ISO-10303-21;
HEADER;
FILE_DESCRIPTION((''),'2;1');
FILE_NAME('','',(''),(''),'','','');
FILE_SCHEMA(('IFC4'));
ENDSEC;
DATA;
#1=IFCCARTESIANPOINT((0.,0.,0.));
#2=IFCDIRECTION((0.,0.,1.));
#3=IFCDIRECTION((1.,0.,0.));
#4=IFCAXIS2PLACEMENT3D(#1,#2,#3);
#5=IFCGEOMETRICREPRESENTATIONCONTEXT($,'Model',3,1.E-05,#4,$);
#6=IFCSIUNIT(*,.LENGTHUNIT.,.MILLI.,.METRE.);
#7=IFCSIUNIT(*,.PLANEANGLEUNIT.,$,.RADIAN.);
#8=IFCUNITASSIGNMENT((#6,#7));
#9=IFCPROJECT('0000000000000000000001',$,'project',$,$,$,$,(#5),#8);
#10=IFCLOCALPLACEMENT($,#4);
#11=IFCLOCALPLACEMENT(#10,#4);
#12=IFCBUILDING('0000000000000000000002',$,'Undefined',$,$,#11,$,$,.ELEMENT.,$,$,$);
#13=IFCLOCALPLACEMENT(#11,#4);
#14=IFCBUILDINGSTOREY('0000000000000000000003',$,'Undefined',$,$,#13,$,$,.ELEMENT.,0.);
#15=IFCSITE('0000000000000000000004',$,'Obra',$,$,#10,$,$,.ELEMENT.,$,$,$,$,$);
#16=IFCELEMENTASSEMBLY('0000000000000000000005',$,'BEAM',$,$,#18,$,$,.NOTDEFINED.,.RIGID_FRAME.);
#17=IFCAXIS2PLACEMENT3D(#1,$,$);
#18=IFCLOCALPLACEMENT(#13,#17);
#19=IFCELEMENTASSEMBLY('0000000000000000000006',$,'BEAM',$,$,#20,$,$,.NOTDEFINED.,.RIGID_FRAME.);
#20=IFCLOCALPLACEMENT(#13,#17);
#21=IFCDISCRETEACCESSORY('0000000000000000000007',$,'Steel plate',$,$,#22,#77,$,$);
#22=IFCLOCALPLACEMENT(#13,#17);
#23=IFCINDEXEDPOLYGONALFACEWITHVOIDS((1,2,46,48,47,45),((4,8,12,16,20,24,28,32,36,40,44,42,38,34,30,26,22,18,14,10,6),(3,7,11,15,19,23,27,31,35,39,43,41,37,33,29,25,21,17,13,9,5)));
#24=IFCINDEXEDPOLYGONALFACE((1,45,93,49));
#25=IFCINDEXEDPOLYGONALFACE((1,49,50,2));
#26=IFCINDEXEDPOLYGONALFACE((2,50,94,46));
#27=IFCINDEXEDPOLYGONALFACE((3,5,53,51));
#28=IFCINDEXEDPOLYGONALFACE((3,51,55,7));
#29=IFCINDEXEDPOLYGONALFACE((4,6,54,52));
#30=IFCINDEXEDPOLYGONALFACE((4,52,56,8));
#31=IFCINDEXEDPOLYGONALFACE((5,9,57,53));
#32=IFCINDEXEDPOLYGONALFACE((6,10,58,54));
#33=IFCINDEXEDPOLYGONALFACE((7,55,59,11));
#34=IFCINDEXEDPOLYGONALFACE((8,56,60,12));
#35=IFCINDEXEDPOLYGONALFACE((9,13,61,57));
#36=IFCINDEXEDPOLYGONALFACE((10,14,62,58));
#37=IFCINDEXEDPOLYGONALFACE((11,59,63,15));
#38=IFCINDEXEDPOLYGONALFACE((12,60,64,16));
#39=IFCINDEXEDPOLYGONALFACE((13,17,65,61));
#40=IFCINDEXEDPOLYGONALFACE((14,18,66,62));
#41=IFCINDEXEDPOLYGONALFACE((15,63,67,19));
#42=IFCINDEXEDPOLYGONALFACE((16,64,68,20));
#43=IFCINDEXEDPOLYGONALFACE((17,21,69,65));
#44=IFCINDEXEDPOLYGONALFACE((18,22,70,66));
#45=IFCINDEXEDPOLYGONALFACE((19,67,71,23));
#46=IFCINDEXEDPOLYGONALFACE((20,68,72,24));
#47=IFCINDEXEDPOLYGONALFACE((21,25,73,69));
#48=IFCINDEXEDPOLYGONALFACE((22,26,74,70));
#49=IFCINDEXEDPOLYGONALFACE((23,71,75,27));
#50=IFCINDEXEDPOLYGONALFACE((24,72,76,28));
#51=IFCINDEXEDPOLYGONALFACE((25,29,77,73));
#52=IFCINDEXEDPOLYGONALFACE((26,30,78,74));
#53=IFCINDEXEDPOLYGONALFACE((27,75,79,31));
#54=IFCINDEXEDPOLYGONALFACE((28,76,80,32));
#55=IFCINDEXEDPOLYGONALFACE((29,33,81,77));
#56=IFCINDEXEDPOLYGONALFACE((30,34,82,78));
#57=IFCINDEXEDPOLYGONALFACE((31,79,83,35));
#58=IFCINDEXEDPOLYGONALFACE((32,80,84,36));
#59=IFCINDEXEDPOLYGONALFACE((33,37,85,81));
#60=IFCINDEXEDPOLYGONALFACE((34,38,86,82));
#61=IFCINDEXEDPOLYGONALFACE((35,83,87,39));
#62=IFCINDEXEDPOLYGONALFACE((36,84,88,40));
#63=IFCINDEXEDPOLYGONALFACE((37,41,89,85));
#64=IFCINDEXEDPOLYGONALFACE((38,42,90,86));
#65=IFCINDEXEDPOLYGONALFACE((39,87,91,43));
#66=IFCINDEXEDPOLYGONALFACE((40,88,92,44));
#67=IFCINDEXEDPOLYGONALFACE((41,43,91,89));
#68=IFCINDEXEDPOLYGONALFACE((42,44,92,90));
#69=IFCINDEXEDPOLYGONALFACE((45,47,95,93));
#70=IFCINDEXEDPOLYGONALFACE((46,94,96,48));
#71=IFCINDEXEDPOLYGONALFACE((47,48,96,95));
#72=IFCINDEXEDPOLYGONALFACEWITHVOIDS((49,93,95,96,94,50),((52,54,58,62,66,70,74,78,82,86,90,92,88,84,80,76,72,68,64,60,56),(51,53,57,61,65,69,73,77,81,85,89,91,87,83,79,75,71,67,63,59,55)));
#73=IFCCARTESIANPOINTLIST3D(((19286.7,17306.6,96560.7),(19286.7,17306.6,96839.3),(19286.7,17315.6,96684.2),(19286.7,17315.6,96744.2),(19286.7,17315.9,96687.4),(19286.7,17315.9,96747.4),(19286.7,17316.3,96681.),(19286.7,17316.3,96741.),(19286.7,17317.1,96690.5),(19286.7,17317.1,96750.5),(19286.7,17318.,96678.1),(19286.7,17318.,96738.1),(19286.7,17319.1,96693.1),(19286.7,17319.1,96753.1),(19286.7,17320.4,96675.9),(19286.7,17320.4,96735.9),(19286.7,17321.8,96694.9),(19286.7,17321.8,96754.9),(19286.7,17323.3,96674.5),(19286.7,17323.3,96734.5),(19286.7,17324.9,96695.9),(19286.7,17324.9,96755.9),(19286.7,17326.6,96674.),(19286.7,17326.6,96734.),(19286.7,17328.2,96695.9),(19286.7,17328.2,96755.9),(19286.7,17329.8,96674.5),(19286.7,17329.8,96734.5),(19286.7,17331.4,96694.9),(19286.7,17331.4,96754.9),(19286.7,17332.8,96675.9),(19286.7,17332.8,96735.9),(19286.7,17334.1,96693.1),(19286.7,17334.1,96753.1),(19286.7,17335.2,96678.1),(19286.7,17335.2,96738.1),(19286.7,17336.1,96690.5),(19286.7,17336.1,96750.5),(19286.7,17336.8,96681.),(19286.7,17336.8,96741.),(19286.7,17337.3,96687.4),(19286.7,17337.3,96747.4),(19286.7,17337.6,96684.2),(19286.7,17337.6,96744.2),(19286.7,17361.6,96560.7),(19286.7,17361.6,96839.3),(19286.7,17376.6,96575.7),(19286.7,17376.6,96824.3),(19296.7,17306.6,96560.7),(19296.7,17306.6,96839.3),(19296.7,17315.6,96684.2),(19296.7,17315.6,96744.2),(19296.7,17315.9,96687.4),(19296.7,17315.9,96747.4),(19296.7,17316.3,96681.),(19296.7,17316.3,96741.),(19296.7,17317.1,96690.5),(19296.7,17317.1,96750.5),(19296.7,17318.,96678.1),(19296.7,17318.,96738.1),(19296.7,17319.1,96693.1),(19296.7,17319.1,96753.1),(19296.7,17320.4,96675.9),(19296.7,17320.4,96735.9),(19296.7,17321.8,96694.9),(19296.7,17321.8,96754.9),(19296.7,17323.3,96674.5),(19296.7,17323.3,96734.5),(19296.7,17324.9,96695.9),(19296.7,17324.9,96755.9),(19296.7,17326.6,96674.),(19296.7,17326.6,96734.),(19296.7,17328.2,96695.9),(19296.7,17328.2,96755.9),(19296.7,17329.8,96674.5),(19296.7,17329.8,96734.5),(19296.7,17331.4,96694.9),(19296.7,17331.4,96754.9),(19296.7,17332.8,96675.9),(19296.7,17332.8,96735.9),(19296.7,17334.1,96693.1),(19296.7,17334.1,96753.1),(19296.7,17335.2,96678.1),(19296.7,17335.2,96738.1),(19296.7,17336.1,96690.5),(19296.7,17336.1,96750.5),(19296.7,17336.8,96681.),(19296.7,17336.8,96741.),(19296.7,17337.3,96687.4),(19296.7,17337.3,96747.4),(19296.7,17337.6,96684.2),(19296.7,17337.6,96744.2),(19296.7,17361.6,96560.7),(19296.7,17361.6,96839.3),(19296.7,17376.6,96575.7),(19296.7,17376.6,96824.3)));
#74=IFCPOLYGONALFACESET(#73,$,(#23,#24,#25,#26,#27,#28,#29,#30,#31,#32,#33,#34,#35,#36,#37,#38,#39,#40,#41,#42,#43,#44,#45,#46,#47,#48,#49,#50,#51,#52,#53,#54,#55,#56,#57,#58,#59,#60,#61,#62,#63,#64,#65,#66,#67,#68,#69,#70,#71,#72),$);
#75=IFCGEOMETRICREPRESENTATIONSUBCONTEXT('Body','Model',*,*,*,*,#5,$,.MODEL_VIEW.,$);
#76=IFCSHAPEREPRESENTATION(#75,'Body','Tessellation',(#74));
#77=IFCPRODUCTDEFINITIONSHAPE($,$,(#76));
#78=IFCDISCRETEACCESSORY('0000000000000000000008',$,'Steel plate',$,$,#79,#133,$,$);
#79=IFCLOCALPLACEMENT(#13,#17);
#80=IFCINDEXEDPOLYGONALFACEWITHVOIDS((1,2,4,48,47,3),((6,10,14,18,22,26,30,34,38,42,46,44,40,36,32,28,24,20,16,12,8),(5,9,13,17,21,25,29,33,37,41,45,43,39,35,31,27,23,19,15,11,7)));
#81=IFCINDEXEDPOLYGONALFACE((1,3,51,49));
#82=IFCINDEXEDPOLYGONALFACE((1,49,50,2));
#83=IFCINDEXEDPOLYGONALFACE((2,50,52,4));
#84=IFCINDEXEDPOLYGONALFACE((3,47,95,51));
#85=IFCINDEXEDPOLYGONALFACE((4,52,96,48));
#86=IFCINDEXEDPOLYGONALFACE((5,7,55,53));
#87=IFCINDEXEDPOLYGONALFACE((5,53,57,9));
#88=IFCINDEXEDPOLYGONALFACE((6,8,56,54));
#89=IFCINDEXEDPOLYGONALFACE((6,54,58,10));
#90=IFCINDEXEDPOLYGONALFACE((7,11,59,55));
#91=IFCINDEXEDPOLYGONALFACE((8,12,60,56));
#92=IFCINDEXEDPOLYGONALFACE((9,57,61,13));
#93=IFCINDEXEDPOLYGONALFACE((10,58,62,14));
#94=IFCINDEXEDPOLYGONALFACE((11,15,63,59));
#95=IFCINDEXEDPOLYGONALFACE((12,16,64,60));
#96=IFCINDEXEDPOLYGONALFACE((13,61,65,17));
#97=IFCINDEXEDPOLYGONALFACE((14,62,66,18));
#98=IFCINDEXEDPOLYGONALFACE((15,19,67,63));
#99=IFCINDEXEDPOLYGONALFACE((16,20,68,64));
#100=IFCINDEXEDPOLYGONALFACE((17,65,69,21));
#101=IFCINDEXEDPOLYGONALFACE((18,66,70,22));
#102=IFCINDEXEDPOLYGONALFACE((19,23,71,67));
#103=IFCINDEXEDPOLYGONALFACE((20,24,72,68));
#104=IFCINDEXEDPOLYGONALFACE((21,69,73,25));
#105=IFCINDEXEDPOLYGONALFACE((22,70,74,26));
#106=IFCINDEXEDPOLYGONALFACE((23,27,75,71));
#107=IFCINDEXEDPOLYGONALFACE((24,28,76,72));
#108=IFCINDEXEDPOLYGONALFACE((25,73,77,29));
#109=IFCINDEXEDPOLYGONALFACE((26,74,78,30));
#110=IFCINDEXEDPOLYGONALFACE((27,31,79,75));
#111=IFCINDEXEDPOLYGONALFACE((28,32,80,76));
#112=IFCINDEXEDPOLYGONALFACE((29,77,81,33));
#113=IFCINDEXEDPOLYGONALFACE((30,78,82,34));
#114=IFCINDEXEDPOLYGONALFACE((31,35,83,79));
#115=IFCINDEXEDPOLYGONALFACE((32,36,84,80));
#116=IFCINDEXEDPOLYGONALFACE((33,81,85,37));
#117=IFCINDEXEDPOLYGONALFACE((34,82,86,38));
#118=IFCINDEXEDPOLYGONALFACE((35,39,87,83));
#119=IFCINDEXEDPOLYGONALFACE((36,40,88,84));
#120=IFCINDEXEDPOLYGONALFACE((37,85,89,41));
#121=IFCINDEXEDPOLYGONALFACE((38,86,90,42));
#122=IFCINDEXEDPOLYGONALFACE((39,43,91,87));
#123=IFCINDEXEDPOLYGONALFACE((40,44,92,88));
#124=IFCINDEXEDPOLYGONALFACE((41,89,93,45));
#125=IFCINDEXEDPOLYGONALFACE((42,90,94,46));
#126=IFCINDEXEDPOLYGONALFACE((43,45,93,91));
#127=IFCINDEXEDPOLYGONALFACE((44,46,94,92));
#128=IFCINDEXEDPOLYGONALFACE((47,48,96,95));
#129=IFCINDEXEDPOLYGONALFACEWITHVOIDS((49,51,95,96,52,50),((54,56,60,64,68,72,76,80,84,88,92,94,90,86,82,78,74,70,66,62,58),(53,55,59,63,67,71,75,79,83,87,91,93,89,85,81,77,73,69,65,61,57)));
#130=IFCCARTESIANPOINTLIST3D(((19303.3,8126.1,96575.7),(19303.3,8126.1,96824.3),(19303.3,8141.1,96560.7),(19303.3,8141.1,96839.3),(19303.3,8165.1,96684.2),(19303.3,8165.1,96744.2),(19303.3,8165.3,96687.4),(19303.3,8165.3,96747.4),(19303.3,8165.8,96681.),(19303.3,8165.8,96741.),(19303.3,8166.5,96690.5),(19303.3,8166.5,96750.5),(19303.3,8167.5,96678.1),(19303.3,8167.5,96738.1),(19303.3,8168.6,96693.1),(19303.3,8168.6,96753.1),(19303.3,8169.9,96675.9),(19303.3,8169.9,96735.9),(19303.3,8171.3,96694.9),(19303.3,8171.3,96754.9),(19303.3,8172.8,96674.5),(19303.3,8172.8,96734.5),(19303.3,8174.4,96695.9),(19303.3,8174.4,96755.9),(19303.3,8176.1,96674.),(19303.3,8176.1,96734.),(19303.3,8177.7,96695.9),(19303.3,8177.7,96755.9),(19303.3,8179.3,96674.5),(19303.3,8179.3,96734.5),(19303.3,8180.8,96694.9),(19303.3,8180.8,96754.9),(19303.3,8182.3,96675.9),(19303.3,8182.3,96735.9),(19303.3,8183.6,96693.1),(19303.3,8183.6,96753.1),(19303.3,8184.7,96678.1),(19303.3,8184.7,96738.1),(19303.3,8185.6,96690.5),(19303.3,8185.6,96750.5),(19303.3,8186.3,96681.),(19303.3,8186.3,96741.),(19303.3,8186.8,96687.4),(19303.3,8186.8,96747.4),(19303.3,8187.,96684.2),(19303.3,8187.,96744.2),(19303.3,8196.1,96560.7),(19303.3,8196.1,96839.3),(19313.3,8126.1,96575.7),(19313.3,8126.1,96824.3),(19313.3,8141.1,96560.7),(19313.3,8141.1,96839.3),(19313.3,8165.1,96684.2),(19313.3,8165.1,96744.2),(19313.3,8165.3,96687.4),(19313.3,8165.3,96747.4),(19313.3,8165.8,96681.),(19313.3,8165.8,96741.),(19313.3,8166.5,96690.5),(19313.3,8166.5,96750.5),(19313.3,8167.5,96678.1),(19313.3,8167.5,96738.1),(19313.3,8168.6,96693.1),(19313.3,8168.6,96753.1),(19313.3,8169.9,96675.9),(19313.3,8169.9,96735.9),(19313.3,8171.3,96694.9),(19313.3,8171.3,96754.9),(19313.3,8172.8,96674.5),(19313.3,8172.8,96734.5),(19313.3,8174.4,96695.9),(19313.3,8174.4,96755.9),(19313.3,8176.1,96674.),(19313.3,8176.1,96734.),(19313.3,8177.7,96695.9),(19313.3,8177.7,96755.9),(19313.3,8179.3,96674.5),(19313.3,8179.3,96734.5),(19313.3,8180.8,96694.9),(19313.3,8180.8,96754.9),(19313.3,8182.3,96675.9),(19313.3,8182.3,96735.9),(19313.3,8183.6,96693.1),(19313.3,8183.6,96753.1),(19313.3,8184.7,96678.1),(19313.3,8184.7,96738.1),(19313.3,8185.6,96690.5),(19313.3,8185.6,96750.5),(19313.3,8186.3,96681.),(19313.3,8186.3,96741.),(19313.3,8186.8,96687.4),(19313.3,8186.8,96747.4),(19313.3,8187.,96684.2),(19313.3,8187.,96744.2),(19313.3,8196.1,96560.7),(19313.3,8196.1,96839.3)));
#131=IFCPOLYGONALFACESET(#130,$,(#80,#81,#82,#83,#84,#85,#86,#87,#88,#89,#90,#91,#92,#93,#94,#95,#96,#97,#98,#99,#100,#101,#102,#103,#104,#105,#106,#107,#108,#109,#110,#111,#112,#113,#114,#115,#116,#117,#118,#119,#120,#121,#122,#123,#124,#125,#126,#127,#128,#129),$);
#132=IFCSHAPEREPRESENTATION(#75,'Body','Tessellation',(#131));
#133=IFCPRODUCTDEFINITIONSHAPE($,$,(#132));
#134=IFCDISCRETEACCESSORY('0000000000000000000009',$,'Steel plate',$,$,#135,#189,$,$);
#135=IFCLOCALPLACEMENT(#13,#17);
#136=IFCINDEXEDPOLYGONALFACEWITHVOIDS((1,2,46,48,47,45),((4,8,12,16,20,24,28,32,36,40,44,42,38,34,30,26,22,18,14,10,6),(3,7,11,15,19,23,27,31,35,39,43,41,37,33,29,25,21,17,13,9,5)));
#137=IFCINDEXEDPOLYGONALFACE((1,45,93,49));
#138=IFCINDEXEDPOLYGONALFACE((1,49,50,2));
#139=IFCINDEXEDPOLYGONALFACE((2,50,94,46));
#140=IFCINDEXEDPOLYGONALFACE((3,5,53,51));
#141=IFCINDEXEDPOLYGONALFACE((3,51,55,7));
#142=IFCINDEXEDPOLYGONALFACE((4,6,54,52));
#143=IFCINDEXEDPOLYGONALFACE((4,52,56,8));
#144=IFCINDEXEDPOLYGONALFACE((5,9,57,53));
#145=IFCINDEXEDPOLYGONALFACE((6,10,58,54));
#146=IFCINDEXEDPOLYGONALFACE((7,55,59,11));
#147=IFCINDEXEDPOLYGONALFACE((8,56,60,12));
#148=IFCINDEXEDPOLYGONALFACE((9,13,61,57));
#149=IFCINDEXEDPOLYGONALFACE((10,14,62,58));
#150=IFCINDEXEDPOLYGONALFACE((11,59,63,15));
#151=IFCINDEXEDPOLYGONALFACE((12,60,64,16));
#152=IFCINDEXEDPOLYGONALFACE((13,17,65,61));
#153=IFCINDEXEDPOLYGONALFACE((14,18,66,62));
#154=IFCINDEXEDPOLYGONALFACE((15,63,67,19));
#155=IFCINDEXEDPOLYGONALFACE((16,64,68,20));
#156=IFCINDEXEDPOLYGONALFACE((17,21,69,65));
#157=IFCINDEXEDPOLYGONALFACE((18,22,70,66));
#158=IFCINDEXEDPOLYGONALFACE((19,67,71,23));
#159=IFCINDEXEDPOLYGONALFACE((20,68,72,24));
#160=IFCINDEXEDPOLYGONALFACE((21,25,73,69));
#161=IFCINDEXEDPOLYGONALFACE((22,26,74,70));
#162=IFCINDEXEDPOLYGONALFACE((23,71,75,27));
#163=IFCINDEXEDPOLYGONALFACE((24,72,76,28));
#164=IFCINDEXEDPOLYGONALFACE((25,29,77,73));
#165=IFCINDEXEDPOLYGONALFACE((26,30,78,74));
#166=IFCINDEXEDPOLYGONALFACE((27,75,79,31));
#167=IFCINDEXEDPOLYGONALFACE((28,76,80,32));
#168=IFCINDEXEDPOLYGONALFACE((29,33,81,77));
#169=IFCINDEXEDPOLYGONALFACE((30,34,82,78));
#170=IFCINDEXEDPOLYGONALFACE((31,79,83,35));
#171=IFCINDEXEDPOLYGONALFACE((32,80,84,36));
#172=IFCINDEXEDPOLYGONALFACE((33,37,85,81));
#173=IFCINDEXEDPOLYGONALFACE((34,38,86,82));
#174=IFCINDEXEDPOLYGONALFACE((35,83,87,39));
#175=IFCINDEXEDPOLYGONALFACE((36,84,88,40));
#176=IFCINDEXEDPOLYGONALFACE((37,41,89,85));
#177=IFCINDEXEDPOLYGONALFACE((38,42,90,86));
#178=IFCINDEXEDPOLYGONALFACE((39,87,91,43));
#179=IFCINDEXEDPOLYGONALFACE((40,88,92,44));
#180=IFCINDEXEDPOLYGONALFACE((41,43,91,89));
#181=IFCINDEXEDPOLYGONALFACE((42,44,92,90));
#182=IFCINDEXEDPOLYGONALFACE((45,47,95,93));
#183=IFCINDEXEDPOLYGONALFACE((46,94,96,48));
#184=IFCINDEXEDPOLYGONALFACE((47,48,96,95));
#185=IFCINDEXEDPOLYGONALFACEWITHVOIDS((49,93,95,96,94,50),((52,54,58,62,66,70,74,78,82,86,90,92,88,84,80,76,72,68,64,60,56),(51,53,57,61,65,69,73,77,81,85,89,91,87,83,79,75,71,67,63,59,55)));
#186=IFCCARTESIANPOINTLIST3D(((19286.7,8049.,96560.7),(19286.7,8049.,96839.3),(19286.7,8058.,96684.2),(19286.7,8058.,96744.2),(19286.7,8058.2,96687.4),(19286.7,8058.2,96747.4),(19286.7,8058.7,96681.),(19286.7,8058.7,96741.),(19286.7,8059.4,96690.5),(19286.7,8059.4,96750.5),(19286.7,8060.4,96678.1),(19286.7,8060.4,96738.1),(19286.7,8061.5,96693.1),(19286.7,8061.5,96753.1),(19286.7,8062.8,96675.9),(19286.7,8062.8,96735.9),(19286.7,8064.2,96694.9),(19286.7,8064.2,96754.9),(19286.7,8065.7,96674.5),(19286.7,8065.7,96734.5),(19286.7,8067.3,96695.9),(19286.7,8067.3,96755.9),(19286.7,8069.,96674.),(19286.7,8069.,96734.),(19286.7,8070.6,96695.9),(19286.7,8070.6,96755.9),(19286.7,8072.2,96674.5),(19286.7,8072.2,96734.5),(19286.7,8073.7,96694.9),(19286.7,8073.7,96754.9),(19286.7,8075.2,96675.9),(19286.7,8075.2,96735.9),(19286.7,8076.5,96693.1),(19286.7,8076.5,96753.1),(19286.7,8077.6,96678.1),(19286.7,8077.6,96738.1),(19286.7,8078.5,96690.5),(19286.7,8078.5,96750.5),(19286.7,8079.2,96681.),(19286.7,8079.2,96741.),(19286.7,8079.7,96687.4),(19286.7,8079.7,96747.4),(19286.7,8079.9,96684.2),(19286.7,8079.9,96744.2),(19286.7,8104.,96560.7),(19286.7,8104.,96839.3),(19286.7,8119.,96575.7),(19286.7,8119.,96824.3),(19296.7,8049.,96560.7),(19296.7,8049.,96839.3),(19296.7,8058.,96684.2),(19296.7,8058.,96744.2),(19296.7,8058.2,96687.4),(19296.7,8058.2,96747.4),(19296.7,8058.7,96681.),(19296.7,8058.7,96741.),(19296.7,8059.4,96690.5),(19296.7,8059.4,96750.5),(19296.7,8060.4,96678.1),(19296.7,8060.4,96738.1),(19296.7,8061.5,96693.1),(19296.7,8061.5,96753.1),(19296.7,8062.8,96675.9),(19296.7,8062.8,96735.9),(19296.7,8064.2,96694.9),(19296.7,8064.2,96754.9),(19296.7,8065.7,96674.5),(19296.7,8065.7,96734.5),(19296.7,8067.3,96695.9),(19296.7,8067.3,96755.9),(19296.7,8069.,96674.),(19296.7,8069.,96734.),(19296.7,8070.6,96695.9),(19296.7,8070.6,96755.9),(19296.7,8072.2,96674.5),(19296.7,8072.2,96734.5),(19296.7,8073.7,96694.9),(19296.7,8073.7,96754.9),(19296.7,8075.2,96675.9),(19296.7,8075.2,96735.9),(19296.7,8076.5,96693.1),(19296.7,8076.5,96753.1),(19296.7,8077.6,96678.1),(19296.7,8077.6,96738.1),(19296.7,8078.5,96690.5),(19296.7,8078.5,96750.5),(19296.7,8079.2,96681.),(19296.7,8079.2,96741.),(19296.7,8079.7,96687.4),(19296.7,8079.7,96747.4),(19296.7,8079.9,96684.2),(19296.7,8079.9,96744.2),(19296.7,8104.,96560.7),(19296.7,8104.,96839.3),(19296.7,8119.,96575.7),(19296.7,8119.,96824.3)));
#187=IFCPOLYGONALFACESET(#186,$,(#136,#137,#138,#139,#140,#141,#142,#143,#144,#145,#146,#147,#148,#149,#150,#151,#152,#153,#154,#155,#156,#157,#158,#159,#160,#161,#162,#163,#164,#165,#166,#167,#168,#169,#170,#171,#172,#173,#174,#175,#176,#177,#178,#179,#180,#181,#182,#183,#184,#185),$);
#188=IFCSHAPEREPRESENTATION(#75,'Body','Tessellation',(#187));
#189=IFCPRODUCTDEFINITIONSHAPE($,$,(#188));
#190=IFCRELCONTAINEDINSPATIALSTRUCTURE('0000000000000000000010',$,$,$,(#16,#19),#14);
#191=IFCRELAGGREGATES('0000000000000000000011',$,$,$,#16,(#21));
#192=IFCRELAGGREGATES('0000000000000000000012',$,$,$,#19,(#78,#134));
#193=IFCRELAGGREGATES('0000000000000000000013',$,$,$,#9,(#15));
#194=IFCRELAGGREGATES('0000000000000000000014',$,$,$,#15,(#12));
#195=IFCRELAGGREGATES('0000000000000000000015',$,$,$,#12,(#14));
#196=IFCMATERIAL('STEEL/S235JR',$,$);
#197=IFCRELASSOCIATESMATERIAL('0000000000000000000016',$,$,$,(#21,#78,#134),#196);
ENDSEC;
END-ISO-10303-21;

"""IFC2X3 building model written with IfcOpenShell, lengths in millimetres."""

from ifc_helpers import new_model, si_unit, frame, origin_with_axes, origin_2d_with_axis, place, context, subcontext, project, spatial, polyline, circle, outline, extrude, source, transform, mapped, material, element, aggregate, save


model = new_model("IFC2X3")

# Units and contexts
model_context = context("Model", 3, precision=1e-05, world=origin_with_axes())
body_context = subcontext(model_context, "Body", "Model", "MODEL_VIEW")
ifc_project = project(units=[si_unit("LENGTHUNIT", "METRE", prefix="MILLI"), si_unit("PLANEANGLEUNIT", "RADIAN")], contexts=[model_context])

# Site, building, storey
site_placement = place(None, origin_with_axes())
site = spatial("IfcSite", under=ifc_project, at=site_placement, Name="Obra", CompositionType="ELEMENT")
building_placement = place(site_placement, origin_with_axes())
building = spatial("IfcBuilding", under=site, at=building_placement, Name="Undefined", CompositionType="ELEMENT")
storey_placement = place(building_placement, origin_with_axes())
storey = spatial("IfcBuildingStorey", under=building, at=storey_placement, Name="Undefined", CompositionType="ELEMENT", Elevation=0.0)

# Element assemblies
assembly_1_placement = place(storey_placement, origin_with_axes())
assembly_1 = element("IfcElementAssembly", 1, at=assembly_1_placement, inside=storey, Name="BEAM", AssemblyPlace="NOTDEFINED", PredefinedType="RIGID_FRAME")
ifc_material_1 = material(Name="STEEL/S235JR")
assembly_2_placement = place(storey_placement, origin_with_axes())
assembly_2 = element("IfcElementAssembly", 2, at=assembly_2_placement, inside=storey, Name="BEAM", AssemblyPlace="NOTDEFINED", PredefinedType="RIGID_FRAME")

# Discrete accessories, openings
shared_shape_1 = source(origin_with_axes(), body_context, "Body", "SweptSolid", [
    extrude(circle(Radius=11.0, at=origin_2d_with_axis()), frame((0.0, -13.4, 0.0), z_axis=(0.0, 1.0, 0.0), x_axis=(1.0, 0.0, 0.0)), (0.0, 0.0, 1.0), 10.2),
])
discrete_accessory_1_placement = place(assembly_1_placement, frame((19291.7, 17306.6, 96560.7), z_axis=(1.0, 0.0, 0.0), x_axis=(0.0, 1.0, 0.0)))
discrete_accessory_1 = element("IfcDiscreteAccessory", 3, at=discrete_accessory_1_placement, material=ifc_material_1, Name="Steel plate", context=body_context, shape_type="SweptSolid", body=[
    extrude(outline(polyline([(0.0, 0.0), (55.0, 0.0), (70.0, 15.0), (70.0, 263.6), (55.0, 278.6), (0.0, 278.6), (0.0, 0.0)])), frame((0.0, 0.0, -5.0), z_axis=(0.0, 0.0, 1.0), x_axis=(1.0, 0.0, 0.0)), (0.0, 0.0, 1.0), 10.0),
])
opening_1_placement = place(assembly_1_placement, frame((19300.0, 17366.6, 96850.0), z_axis=(0.0, -1.0, 0.0), x_axis=(0.0, 0.0, -1.0)))
element("IfcOpeningElement", 4, at=opening_1_placement, cuts=discrete_accessory_1, ObjectType="Opening", context=body_context, shape_type="MappedRepresentation", body=[
    mapped(shared_shape_1, transform((105.0, 0.0, 40.0))),
    mapped(shared_shape_1, transform((165.0, 0.0, 40.0))),
])
aggregate(assembly_1, [discrete_accessory_1])
discrete_accessory_2_placement = place(assembly_2_placement, frame((19308.3, 8196.1, 96560.7), z_axis=(-1.0, 0.0, 0.0), x_axis=(0.0, -1.0, 0.0)))
discrete_accessory_2 = element("IfcDiscreteAccessory", 5, at=discrete_accessory_2_placement, material=ifc_material_1, Name="Steel plate", context=body_context, shape_type="SweptSolid", body=[
    extrude(outline(polyline([(0.0, 0.0), (55.0, 0.0), (70.0, 15.0), (70.0, 263.6), (55.0, 278.6), (0.0, 278.6), (0.0, 0.0)])), frame((0.0, 0.0, -5.0), z_axis=(0.0, 0.0, 1.0), x_axis=(1.0, 0.0, 0.0)), (0.0, 0.0, 1.0), 10.0),
])
opening_2_placement = place(assembly_2_placement, frame((19300.0, 8136.1, 96850.0), z_axis=(0.0, 1.0, 0.0), x_axis=(0.0, 0.0, -1.0)))
element("IfcOpeningElement", 6, at=opening_2_placement, cuts=discrete_accessory_2, ObjectType="Opening", context=body_context, shape_type="MappedRepresentation", body=[
    mapped(shared_shape_1, transform((105.0, 0.0, 40.0))),
    mapped(shared_shape_1, transform((165.0, 0.0, 40.0))),
])
discrete_accessory_3_placement = place(assembly_2_placement, frame((19291.7, 8049.0, 96560.7), z_axis=(1.0, 0.0, 0.0), x_axis=(0.0, 1.0, 0.0)))
discrete_accessory_3 = element("IfcDiscreteAccessory", 7, at=discrete_accessory_3_placement, material=ifc_material_1, Name="Steel plate", context=body_context, shape_type="SweptSolid", body=[
    extrude(outline(polyline([(0.0, 0.0), (55.0, 0.0), (70.0, 15.0), (70.0, 263.6), (55.0, 278.6), (0.0, 278.6), (0.0, 0.0)])), frame((0.0, 0.0, -5.0), z_axis=(0.0, 0.0, 1.0), x_axis=(1.0, 0.0, 0.0)), (0.0, 0.0, 1.0), 10.0),
])
opening_3_placement = place(assembly_2_placement, frame((19300.0, 8109.0, 96850.0), z_axis=(0.0, -1.0, 0.0), x_axis=(0.0, 0.0, -1.0)))
element("IfcOpeningElement", 8, at=opening_3_placement, cuts=discrete_accessory_3, ObjectType="Opening", context=body_context, shape_type="MappedRepresentation", body=[
    mapped(shared_shape_1, transform((105.0, 0.0, 40.0))),
    mapped(shared_shape_1, transform((165.0, 0.0, 40.0))),
])
aggregate(assembly_2, [discrete_accessory_2, discrete_accessory_3])

save(model, "model.ifc")
